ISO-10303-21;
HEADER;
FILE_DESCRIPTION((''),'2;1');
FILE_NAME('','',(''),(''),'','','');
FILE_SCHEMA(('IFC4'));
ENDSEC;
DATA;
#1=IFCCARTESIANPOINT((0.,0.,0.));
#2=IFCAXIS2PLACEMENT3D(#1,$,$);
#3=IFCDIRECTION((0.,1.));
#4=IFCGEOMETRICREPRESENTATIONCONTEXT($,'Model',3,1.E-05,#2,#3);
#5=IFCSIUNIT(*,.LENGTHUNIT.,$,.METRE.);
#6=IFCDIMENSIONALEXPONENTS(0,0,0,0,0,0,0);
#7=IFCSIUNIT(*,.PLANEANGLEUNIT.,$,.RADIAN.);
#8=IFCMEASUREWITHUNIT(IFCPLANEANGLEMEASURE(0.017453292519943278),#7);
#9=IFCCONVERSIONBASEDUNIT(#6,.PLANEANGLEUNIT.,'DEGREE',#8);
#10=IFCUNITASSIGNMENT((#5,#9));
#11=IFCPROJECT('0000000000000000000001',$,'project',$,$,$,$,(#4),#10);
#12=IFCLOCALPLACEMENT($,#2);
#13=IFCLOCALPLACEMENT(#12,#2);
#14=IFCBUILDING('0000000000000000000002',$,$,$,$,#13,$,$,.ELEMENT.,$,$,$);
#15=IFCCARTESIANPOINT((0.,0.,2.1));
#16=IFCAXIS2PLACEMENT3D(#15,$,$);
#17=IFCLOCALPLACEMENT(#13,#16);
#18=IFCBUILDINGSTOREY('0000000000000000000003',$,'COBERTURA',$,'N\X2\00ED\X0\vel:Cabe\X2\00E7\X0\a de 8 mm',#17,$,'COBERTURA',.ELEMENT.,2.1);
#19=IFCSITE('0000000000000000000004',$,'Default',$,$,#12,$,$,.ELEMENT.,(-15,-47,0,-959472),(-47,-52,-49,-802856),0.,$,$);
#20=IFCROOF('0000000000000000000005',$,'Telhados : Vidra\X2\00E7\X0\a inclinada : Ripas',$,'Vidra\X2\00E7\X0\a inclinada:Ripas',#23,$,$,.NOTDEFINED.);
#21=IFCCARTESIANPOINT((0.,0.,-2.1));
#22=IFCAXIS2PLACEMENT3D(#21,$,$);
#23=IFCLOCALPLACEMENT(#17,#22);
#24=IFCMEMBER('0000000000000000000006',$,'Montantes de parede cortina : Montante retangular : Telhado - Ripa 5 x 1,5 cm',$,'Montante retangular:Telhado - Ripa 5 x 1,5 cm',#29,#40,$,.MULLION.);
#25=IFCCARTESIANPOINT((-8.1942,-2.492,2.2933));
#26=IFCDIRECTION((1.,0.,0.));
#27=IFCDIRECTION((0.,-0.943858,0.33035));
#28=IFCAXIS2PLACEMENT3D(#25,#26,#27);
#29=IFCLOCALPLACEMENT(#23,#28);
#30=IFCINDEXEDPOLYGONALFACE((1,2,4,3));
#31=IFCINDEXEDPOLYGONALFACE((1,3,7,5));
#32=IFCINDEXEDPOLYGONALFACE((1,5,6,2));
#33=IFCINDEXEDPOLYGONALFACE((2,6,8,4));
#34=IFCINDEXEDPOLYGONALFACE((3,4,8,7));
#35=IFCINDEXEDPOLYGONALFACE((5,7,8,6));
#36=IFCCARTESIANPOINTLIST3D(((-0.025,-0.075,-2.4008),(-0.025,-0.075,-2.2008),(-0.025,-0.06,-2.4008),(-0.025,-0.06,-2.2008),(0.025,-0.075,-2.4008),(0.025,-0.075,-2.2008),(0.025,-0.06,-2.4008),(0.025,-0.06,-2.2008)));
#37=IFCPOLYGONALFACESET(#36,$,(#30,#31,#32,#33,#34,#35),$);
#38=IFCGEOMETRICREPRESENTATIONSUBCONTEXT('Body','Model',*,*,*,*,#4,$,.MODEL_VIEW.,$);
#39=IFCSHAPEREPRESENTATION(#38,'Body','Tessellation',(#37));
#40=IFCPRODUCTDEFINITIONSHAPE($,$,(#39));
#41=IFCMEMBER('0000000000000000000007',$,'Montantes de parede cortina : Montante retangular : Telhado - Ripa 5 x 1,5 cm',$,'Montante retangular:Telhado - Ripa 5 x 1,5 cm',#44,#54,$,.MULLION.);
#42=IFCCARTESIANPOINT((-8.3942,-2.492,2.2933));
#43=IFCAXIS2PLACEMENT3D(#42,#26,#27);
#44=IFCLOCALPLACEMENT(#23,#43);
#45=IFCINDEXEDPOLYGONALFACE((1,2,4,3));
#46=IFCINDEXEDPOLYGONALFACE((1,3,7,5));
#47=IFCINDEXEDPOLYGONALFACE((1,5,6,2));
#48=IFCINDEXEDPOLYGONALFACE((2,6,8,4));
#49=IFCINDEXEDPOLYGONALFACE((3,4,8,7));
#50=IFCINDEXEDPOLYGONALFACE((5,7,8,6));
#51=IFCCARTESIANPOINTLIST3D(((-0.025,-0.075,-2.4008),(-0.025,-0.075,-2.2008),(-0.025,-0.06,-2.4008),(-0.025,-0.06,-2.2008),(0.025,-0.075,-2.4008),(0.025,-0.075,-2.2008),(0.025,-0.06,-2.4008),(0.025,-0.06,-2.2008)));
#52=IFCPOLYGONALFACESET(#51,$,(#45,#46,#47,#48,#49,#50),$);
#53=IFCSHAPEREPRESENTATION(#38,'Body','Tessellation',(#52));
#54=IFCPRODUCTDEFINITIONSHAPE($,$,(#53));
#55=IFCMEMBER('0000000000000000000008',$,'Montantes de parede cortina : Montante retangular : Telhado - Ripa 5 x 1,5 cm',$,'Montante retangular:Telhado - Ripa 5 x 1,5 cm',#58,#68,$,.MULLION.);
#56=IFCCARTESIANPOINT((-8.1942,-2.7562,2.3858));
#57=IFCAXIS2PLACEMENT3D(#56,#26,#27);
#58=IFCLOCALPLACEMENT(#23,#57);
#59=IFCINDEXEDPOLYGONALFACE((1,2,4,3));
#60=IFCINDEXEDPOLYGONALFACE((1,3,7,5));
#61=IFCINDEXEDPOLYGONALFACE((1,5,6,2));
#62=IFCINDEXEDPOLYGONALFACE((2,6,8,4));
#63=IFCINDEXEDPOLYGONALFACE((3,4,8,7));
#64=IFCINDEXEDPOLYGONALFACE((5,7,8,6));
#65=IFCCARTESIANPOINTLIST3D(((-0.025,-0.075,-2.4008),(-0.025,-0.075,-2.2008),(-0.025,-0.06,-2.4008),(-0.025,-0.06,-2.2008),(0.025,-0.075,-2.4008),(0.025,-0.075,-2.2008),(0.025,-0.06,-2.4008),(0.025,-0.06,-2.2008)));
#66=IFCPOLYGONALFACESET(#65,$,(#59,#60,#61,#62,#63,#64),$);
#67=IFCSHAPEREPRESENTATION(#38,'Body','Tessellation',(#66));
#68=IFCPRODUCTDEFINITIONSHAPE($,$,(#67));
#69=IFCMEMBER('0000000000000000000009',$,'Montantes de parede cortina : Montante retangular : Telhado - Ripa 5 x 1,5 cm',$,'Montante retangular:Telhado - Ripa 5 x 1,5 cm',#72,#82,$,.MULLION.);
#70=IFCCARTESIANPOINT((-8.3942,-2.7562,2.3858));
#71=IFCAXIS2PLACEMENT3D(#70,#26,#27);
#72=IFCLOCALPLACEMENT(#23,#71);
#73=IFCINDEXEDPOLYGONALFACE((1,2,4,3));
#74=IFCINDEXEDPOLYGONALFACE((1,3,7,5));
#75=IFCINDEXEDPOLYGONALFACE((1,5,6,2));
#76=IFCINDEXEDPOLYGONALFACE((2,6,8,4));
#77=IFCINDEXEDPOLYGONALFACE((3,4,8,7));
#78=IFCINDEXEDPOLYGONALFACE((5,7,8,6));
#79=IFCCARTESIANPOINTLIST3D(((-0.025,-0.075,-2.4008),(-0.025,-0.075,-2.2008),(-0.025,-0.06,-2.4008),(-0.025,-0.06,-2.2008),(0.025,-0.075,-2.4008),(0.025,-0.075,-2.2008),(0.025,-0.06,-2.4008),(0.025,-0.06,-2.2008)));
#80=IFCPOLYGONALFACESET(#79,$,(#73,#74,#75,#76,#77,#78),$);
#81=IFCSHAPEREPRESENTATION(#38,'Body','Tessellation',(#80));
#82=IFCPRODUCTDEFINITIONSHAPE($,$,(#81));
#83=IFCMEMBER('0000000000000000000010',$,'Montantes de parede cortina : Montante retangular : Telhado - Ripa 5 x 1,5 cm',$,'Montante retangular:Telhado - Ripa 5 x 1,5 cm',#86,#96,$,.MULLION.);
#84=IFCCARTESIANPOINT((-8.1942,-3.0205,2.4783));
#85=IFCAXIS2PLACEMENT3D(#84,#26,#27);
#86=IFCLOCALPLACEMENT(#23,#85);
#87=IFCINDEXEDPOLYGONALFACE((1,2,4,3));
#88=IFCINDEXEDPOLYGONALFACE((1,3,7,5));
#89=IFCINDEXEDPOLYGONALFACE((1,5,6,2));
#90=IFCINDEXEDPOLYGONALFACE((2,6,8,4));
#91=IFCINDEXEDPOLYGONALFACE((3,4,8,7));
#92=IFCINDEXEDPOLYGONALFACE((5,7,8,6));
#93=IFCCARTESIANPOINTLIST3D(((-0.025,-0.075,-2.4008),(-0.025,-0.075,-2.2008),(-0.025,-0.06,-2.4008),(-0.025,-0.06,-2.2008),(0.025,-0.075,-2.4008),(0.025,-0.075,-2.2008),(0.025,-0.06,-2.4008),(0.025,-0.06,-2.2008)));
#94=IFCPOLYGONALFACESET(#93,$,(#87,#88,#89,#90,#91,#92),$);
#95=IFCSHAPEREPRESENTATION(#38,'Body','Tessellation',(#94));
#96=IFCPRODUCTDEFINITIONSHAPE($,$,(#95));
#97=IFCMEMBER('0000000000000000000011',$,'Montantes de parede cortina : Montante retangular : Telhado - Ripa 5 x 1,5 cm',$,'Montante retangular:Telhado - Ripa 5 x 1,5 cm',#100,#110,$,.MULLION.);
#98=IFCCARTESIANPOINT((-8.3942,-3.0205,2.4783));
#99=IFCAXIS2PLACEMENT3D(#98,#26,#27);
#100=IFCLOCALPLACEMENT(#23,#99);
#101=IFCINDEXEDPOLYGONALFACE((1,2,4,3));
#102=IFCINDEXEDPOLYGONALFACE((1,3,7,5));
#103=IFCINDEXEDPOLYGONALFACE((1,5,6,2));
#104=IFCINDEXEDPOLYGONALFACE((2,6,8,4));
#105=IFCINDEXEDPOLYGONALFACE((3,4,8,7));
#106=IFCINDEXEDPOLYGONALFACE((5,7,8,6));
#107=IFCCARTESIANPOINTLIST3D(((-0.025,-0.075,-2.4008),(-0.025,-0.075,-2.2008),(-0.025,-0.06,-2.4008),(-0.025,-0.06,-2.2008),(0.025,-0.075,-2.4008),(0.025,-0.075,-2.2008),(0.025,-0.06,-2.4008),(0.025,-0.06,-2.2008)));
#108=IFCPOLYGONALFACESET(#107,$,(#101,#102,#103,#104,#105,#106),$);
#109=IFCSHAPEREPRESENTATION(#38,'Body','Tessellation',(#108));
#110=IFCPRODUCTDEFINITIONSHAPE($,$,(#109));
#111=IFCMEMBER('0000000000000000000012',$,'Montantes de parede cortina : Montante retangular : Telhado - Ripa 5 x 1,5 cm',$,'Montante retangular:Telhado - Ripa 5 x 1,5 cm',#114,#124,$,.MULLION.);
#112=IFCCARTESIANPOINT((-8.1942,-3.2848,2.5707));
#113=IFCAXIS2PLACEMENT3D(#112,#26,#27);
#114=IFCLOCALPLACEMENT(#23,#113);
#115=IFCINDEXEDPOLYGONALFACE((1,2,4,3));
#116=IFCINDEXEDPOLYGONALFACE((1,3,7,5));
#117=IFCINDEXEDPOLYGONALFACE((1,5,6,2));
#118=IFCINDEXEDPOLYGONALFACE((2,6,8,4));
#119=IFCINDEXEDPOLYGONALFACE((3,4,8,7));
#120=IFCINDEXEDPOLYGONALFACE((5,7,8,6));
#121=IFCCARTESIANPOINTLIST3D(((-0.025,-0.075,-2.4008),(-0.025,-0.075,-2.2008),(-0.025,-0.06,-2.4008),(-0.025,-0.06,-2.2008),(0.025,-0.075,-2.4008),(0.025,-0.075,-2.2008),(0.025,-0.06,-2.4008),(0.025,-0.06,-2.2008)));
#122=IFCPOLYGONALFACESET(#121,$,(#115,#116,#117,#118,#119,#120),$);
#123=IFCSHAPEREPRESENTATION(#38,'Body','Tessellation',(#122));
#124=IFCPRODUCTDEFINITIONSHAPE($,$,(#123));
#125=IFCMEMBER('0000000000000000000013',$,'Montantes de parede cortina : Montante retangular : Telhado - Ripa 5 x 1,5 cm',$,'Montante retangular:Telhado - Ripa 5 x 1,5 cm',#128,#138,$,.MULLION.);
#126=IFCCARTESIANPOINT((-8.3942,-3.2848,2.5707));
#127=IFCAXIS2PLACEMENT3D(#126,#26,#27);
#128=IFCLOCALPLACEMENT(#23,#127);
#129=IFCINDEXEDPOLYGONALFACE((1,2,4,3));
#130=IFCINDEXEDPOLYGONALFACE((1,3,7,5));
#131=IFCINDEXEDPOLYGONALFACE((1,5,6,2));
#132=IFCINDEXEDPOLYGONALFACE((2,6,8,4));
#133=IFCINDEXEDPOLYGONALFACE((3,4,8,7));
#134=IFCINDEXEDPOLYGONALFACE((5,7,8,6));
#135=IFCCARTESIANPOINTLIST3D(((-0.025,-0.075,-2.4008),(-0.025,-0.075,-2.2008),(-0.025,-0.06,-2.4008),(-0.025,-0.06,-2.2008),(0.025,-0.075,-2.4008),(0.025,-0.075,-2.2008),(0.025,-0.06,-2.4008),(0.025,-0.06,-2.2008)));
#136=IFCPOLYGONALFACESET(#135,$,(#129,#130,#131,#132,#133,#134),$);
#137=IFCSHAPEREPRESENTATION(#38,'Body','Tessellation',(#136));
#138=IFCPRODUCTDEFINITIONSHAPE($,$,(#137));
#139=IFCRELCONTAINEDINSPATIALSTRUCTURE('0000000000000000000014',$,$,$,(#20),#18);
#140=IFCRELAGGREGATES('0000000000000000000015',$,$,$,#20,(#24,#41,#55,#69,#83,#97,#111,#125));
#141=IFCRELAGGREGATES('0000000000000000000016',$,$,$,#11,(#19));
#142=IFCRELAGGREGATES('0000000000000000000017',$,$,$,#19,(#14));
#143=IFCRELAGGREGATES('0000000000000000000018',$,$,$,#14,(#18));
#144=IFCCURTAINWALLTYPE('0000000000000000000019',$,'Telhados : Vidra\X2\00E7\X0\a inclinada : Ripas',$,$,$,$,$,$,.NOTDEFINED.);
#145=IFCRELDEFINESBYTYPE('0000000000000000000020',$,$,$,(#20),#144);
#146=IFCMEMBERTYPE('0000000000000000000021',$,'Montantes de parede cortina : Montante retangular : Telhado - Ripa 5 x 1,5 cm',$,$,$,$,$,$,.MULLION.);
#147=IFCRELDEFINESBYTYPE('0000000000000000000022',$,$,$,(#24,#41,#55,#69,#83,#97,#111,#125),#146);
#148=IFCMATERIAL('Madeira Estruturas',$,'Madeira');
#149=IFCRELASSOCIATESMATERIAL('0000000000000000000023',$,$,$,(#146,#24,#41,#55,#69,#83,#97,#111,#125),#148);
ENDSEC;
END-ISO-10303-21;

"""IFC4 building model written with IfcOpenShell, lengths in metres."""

from ifc_helpers import new_model, entity, si_unit, converted_unit, direction, frame, origin, place, context, subcontext, project, spatial, indexed_curve, outline, extrude, source, transform, mapped, material, type_object, type_shapes, element, aggregate, save


model = new_model("IFC4")

# Units and contexts
model_context = context("Model", 3, precision=1e-05, world=origin(), true_north=direction((0.0, 1.0)))
body_context = subcontext(model_context, "Body", "Model", "MODEL_VIEW")
ifc_project = project(units=[si_unit("LENGTHUNIT", "METRE"), converted_unit("PLANEANGLEUNIT", "DEGREE", entity("IfcPlaneAngleMeasure", 0.017453292519943278), si_unit("PLANEANGLEUNIT", "RADIAN"), dimensions=[0, 0, 0, 0, 0, 0, 0])], contexts=[model_context])

# Site, building, storey
site_placement = place(None, origin())
site = spatial("IfcSite", under=ifc_project, at=site_placement, Name="Default", CompositionType="ELEMENT", RefLatitude=(-15, -47, 0, -959472), RefLongitude=(-47, -52, -49, -802856), RefElevation=0.0)
building_placement = place(site_placement, origin())
building = spatial("IfcBuilding", under=site, at=building_placement, CompositionType="ELEMENT")
storey_placement = place(building_placement, frame((0.0, 0.0, 2.1)))
storey = spatial("IfcBuildingStorey", under=building, at=storey_placement, Name="COBERTURA", ObjectType="Nível:Cabeça de 8 mm", LongName="COBERTURA", CompositionType="ELEMENT", Elevation=2.1)

# Roof, members
curtain_wall_type = type_object("IfcCurtainWallType", Name="Telhados : Vidraça inclinada : Ripas", PredefinedType="NOTDEFINED")
roof_placement = place(storey_placement, frame((0.0, 0.0, -2.1)))
roof = element("IfcRoof", 1, at=roof_placement, inside=storey, type_object=curtain_wall_type, Name="Telhados : Vidraça inclinada : Ripas", ObjectType="Vidraça inclinada:Ripas", PredefinedType="NOTDEFINED")
ifc_material_1 = material(Name="Madeira Estruturas", Category="Madeira")
member_type_1 = type_object("IfcMemberType", Name="Montantes de parede cortina : Montante retangular : Telhado - Ripa 5 x 1,5 cm", PredefinedType="MULLION", material=ifc_material_1)
shared_shape_1 = source(origin(), body_context, "Body", "SweptSolid", [
    extrude(outline(indexed_curve([(-0.025, -0.0075), (0.025, -0.0075), (0.025, 0.0075), (-0.025, 0.0075), (-0.025, -0.0075)], self_intersect=False)), frame((0.0, -0.0675, -2.4008), z_axis=(0.0, 0.0, 1.0), x_axis=(-1.0, 0.0, 0.0)), (0.0, 0.0, 1.0), 0.2),
])
type_shapes(member_type_1, [shared_shape_1])
member_1_placement = place(roof_placement, frame((-8.1942, -2.492, 2.2933), z_axis=(1.0, 0.0, 0.0), x_axis=(0.0, -0.943858, 0.33035)))
member_1 = element("IfcMember", 2, at=member_1_placement, type_object=member_type_1, material=ifc_material_1, Name="Montantes de parede cortina : Montante retangular : Telhado - Ripa 5 x 1,5 cm", ObjectType="Montante retangular:Telhado - Ripa 5 x 1,5 cm", PredefinedType="MULLION", context=body_context, shape_type="MappedRepresentation", body=[
    mapped(shared_shape_1, transform((0.0, 0.0, 0.0), scale=1.0)),
])
member_2_placement = place(roof_placement, frame((-8.3942, -2.492, 2.2933), z_axis=(1.0, 0.0, 0.0), x_axis=(0.0, -0.943858, 0.33035)))
member_2 = element("IfcMember", 3, at=member_2_placement, type_object=member_type_1, material=ifc_material_1, Name="Montantes de parede cortina : Montante retangular : Telhado - Ripa 5 x 1,5 cm", ObjectType="Montante retangular:Telhado - Ripa 5 x 1,5 cm", PredefinedType="MULLION", context=body_context, shape_type="MappedRepresentation", body=[
    mapped(shared_shape_1, transform((0.0, 0.0, 0.0), scale=1.0)),
])
member_3_placement = place(roof_placement, frame((-8.1942, -2.7562, 2.3858), z_axis=(1.0, 0.0, 0.0), x_axis=(0.0, -0.943858, 0.33035)))
member_3 = element("IfcMember", 4, at=member_3_placement, type_object=member_type_1, material=ifc_material_1, Name="Montantes de parede cortina : Montante retangular : Telhado - Ripa 5 x 1,5 cm", ObjectType="Montante retangular:Telhado - Ripa 5 x 1,5 cm", PredefinedType="MULLION", context=body_context, shape_type="MappedRepresentation", body=[
    mapped(shared_shape_1, transform((0.0, 0.0, 0.0), scale=1.0)),
])
member_4_placement = place(roof_placement, frame((-8.3942, -2.7562, 2.3858), z_axis=(1.0, 0.0, 0.0), x_axis=(0.0, -0.943858, 0.33035)))
member_4 = element("IfcMember", 5, at=member_4_placement, type_object=member_type_1, material=ifc_material_1, Name="Montantes de parede cortina : Montante retangular : Telhado - Ripa 5 x 1,5 cm", ObjectType="Montante retangular:Telhado - Ripa 5 x 1,5 cm", PredefinedType="MULLION", context=body_context, shape_type="MappedRepresentation", body=[
    mapped(shared_shape_1, transform((0.0, 0.0, 0.0), scale=1.0)),
])
member_5_placement = place(roof_placement, frame((-8.1942, -3.0205, 2.4783), z_axis=(1.0, 0.0, 0.0), x_axis=(0.0, -0.943858, 0.33035)))
member_5 = element("IfcMember", 6, at=member_5_placement, type_object=member_type_1, material=ifc_material_1, Name="Montantes de parede cortina : Montante retangular : Telhado - Ripa 5 x 1,5 cm", ObjectType="Montante retangular:Telhado - Ripa 5 x 1,5 cm", PredefinedType="MULLION", context=body_context, shape_type="MappedRepresentation", body=[
    mapped(shared_shape_1, transform((0.0, 0.0, 0.0), scale=1.0)),
])
member_6_placement = place(roof_placement, frame((-8.3942, -3.0205, 2.4783), z_axis=(1.0, 0.0, 0.0), x_axis=(0.0, -0.943858, 0.33035)))
member_6 = element("IfcMember", 7, at=member_6_placement, type_object=member_type_1, material=ifc_material_1, Name="Montantes de parede cortina : Montante retangular : Telhado - Ripa 5 x 1,5 cm", ObjectType="Montante retangular:Telhado - Ripa 5 x 1,5 cm", PredefinedType="MULLION", context=body_context, shape_type="MappedRepresentation", body=[
    mapped(shared_shape_1, transform((0.0, 0.0, 0.0), scale=1.0)),
])
member_7_placement = place(roof_placement, frame((-8.1942, -3.2848, 2.5707), z_axis=(1.0, 0.0, 0.0), x_axis=(0.0, -0.943858, 0.33035)))
member_7 = element("IfcMember", 8, at=member_7_placement, type_object=member_type_1, material=ifc_material_1, Name="Montantes de parede cortina : Montante retangular : Telhado - Ripa 5 x 1,5 cm", ObjectType="Montante retangular:Telhado - Ripa 5 x 1,5 cm", PredefinedType="MULLION", context=body_context, shape_type="MappedRepresentation", body=[
    mapped(shared_shape_1, transform((0.0, 0.0, 0.0), scale=1.0)),
])
member_8_placement = place(roof_placement, frame((-8.3942, -3.2848, 2.5707), z_axis=(1.0, 0.0, 0.0), x_axis=(0.0, -0.943858, 0.33035)))
member_8 = element("IfcMember", 9, at=member_8_placement, type_object=member_type_1, material=ifc_material_1, Name="Montantes de parede cortina : Montante retangular : Telhado - Ripa 5 x 1,5 cm", ObjectType="Montante retangular:Telhado - Ripa 5 x 1,5 cm", PredefinedType="MULLION", context=body_context, shape_type="MappedRepresentation", body=[
    mapped(shared_shape_1, transform((0.0, 0.0, 0.0), scale=1.0)),
])
aggregate(roof, [member_1, member_2, member_3, member_4, member_5, member_6, member_7, member_8])

save(model, "model.ifc")
